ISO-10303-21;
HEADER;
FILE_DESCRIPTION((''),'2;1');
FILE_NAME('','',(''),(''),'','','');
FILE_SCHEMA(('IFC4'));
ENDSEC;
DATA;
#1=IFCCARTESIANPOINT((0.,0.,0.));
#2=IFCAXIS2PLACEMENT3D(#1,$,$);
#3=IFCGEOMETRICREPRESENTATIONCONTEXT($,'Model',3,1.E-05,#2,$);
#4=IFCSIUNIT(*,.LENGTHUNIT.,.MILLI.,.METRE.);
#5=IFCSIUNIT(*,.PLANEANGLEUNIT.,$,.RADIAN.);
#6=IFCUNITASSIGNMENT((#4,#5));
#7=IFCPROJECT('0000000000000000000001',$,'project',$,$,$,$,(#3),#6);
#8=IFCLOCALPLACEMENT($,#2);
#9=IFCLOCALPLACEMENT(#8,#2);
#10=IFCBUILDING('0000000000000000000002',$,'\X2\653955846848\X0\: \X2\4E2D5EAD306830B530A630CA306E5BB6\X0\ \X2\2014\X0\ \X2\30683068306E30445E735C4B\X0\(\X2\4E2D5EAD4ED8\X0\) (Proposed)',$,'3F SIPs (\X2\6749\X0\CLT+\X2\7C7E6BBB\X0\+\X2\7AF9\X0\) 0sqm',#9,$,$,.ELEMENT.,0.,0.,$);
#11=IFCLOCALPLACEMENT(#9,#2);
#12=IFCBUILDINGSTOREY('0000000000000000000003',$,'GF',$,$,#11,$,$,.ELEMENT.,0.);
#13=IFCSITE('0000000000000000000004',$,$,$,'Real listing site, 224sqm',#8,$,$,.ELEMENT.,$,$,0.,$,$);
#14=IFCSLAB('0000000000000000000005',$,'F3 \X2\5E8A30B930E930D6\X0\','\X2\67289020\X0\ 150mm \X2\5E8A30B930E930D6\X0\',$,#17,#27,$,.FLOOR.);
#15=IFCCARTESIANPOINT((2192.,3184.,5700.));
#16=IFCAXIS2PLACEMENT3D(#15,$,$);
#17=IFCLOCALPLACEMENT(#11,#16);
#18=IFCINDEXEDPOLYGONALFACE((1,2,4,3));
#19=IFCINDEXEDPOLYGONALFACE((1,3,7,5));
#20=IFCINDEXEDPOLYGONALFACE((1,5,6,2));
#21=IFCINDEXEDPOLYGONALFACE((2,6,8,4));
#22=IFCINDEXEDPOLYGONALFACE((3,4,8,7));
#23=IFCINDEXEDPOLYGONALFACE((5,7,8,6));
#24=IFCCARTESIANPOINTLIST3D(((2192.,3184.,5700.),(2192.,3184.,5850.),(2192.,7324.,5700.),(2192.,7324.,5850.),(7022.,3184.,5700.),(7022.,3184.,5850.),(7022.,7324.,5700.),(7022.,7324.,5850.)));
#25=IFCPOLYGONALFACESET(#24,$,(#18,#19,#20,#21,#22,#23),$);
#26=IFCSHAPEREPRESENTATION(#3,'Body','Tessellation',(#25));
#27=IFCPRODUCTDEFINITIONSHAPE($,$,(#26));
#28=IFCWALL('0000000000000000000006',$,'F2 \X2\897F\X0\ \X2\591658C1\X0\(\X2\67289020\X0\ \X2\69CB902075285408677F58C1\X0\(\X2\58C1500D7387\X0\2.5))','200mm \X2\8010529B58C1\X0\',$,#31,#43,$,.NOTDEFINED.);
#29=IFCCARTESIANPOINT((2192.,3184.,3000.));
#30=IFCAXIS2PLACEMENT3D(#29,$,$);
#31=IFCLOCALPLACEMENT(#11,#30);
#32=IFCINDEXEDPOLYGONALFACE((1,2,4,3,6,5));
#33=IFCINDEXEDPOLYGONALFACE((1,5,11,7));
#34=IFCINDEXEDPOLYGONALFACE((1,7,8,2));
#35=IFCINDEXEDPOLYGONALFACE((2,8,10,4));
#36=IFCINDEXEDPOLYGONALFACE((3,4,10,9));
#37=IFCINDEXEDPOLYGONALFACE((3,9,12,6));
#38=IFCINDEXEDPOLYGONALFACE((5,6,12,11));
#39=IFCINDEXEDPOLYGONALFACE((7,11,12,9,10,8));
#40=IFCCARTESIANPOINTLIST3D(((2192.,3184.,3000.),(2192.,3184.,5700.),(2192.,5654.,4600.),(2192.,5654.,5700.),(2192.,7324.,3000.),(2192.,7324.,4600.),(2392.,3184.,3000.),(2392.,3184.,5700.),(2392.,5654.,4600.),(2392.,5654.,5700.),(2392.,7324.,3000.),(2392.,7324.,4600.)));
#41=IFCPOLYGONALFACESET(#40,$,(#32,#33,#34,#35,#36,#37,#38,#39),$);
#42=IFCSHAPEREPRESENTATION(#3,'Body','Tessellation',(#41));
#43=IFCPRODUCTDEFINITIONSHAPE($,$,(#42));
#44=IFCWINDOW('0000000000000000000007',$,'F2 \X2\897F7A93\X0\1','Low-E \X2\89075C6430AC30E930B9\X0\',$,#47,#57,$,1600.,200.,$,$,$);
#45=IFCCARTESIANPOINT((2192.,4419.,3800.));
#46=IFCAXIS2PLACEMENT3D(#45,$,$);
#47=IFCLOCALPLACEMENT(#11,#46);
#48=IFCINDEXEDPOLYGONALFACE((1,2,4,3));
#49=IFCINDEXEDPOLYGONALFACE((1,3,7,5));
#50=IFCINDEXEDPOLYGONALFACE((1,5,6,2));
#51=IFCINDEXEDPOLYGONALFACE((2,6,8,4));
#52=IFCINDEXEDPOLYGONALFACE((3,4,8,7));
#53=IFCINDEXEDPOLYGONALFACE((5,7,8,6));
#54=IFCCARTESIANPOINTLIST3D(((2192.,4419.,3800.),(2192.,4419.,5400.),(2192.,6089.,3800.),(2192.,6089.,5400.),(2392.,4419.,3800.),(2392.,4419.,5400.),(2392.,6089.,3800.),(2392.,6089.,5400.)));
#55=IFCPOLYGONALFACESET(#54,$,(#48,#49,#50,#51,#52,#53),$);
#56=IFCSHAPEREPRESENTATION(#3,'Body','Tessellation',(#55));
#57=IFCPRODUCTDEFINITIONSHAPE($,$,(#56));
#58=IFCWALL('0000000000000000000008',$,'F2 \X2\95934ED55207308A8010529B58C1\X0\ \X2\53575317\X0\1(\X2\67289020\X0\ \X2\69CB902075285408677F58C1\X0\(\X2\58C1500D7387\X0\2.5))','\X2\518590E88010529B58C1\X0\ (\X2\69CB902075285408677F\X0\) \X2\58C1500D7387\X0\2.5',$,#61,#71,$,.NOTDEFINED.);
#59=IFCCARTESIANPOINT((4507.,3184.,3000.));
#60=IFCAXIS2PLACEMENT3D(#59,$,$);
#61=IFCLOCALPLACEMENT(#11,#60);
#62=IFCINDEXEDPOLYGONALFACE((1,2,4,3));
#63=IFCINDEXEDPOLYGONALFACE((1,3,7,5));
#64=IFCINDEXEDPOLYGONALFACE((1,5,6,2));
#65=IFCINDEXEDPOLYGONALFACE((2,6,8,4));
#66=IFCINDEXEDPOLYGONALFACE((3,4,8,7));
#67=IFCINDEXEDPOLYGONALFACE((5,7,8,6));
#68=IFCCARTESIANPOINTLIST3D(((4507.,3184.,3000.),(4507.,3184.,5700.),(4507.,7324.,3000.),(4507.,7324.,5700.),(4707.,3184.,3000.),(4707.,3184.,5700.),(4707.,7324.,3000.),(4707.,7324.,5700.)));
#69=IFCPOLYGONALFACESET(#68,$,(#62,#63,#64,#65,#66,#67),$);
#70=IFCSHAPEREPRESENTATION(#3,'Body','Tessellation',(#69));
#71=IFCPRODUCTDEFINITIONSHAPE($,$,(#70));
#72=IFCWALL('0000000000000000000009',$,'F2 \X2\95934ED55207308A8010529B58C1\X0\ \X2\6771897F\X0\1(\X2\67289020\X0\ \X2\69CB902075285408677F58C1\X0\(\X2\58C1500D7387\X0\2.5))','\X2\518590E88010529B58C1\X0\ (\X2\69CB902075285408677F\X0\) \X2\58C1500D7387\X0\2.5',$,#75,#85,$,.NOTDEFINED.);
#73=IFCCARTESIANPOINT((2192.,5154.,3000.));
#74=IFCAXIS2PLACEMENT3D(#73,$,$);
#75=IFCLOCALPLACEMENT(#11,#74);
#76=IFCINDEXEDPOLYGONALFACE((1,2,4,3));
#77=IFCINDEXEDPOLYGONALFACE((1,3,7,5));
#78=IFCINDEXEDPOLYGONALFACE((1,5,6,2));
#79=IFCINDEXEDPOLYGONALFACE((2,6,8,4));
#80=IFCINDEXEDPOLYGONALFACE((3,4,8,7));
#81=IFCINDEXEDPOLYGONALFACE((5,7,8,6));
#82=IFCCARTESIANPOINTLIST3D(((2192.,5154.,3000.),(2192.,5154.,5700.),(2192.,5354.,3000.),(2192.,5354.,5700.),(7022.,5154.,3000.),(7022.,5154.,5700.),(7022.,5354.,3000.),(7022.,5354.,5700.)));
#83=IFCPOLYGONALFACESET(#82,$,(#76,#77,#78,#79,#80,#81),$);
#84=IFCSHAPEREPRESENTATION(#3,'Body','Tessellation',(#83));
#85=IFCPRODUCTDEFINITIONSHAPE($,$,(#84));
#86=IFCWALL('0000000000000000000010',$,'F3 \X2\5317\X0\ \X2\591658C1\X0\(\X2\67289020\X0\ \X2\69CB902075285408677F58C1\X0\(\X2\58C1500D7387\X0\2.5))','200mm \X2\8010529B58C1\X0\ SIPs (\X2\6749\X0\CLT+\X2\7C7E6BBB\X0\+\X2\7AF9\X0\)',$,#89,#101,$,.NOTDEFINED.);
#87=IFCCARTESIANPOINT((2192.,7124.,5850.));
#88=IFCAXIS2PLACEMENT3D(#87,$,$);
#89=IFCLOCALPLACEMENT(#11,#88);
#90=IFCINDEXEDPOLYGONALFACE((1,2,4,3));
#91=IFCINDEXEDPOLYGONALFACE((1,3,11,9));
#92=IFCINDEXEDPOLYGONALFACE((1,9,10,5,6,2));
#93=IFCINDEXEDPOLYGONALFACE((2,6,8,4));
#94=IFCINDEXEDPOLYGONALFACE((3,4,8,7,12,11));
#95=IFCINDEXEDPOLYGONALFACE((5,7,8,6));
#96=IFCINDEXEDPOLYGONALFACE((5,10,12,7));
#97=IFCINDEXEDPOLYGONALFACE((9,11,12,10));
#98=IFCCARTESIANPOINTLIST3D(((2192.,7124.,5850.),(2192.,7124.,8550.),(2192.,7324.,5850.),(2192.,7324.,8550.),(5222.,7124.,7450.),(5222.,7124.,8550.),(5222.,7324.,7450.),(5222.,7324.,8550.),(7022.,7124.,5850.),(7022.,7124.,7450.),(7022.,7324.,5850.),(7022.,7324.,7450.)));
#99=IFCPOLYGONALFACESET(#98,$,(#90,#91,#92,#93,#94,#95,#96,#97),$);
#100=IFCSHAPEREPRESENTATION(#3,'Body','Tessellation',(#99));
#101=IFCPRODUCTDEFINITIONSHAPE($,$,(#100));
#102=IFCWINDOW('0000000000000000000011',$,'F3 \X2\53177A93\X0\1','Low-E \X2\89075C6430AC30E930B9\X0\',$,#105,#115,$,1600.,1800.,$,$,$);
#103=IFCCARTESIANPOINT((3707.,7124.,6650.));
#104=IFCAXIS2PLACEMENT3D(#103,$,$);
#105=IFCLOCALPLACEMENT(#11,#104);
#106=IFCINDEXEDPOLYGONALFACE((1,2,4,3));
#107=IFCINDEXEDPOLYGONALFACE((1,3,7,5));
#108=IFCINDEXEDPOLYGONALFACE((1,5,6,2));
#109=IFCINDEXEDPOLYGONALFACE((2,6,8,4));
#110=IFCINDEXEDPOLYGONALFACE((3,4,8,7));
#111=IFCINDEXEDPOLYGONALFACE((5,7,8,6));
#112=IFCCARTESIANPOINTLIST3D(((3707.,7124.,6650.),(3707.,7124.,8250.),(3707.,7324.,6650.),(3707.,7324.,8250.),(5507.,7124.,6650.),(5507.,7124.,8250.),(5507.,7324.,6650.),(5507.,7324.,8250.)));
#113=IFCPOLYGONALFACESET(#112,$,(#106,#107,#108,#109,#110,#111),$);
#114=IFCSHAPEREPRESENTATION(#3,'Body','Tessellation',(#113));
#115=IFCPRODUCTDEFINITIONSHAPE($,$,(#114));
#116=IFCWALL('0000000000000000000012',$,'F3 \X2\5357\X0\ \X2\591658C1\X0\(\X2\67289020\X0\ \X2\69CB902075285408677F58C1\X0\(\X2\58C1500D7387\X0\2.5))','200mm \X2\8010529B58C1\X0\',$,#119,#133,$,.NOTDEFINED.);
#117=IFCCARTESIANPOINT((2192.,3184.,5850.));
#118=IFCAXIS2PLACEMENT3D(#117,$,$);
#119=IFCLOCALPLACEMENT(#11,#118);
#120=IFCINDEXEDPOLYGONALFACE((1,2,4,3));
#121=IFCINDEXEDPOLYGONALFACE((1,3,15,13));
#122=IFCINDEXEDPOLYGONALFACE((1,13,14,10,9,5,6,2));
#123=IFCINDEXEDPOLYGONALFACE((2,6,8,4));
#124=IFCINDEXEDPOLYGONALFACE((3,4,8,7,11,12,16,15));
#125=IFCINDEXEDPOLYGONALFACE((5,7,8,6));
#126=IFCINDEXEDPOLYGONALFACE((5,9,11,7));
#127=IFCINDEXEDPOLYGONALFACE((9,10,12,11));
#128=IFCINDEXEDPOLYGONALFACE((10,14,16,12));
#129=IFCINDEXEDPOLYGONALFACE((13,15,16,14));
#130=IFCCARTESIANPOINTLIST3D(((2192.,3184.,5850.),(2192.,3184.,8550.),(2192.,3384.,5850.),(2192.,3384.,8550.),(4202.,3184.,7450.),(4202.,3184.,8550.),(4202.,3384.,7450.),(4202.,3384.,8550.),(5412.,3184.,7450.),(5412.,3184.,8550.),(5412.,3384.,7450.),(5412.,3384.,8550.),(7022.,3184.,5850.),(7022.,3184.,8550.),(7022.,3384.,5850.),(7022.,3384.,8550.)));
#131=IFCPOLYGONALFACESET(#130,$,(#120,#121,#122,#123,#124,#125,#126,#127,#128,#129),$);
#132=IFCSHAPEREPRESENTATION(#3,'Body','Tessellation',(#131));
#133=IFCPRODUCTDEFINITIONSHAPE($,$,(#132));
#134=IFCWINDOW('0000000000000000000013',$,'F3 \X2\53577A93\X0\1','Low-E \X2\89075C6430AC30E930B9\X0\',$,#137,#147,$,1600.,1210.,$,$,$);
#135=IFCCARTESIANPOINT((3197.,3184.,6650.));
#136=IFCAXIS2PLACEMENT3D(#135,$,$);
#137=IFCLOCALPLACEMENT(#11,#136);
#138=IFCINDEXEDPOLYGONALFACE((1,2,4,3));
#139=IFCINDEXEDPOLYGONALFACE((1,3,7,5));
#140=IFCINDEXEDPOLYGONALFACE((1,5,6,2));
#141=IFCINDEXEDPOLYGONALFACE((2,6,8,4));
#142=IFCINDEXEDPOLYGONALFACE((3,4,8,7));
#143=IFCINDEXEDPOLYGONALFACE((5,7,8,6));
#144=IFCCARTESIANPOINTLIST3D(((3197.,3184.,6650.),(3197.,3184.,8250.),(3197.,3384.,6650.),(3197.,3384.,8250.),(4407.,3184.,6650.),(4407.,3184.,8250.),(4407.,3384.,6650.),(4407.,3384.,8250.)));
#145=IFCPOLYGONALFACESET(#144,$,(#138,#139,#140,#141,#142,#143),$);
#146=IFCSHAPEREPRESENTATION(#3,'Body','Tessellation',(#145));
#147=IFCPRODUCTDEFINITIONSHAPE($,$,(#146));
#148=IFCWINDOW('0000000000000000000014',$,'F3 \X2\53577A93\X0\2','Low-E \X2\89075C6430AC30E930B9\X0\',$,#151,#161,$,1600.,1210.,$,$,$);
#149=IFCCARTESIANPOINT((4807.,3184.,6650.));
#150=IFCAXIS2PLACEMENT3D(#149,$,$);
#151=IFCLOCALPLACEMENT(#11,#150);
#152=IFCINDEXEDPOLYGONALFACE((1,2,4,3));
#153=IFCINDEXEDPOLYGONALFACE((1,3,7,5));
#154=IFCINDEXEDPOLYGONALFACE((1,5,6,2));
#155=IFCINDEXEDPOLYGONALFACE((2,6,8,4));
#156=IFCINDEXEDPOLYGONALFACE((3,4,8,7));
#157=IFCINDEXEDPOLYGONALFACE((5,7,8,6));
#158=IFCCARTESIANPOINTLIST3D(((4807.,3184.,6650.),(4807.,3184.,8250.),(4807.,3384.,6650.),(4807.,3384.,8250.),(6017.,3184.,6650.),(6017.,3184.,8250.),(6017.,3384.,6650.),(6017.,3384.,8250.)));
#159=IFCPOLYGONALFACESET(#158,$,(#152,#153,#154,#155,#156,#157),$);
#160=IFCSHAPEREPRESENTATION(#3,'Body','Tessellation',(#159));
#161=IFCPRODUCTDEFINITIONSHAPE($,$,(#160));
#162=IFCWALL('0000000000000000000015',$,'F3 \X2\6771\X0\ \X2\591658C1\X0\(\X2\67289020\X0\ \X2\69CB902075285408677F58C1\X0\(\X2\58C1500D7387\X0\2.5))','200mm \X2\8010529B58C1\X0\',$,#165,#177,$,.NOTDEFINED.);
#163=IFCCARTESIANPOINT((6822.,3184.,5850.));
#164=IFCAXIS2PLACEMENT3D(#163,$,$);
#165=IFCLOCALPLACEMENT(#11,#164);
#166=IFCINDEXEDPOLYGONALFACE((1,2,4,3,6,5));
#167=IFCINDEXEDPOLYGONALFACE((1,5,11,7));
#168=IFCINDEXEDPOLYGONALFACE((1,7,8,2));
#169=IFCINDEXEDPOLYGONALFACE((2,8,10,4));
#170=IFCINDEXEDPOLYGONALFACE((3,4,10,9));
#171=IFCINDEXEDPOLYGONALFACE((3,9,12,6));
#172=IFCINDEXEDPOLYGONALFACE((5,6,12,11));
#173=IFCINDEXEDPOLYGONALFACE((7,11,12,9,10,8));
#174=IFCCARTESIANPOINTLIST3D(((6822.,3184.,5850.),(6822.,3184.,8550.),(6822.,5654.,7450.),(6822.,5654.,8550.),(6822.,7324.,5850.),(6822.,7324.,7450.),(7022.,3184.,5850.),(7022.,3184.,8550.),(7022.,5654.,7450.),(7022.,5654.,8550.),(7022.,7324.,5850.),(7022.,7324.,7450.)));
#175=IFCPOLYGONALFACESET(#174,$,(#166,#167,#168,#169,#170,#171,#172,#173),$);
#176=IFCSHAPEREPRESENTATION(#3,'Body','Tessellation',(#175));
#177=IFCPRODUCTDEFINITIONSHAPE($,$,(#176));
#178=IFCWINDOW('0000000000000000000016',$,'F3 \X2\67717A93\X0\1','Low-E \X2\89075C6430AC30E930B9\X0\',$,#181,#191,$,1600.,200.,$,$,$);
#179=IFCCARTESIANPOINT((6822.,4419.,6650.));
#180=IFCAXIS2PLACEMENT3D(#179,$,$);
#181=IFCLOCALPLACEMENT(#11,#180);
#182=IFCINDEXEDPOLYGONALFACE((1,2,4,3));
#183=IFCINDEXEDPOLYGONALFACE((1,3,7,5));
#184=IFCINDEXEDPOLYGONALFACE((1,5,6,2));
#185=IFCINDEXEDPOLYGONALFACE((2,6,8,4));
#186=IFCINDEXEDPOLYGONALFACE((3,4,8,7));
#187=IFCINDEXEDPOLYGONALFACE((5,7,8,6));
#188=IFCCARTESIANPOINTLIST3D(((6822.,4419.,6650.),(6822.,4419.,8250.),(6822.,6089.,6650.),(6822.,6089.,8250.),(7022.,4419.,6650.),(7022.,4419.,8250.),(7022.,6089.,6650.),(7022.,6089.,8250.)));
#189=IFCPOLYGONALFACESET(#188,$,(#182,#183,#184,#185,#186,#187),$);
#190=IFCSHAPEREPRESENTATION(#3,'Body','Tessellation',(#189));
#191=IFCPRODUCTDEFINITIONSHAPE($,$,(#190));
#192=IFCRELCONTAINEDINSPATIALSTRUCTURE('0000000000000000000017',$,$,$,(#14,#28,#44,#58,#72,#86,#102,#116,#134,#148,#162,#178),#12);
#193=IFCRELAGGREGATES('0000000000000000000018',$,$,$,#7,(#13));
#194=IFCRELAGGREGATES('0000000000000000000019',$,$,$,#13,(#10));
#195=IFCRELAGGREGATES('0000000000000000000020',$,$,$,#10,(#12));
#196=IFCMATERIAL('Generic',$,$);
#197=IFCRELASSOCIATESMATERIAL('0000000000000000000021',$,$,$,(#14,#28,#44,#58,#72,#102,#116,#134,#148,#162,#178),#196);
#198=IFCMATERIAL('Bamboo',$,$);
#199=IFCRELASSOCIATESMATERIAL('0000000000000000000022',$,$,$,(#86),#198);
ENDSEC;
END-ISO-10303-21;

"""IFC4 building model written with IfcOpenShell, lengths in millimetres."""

from ifc_helpers import new_model, si_unit, frame, frame_2d, origin, place, context, project, spatial, rectangle, extrude, material, element, fill, save


model = new_model("IFC4")

# Units and contexts
model_context = context("Model", 3, precision=1e-05, world=origin())
ifc_project = project(units=[si_unit("LENGTHUNIT", "METRE", prefix="MILLI"), si_unit("PLANEANGLEUNIT", "RADIAN")], contexts=[model_context])

# Site, building, storey
site_placement = place(None, origin())
site = spatial("IfcSite", under=ifc_project, at=site_placement, ObjectType="Real listing site, 224sqm", CompositionType="ELEMENT", RefElevation=0.0)
building_placement = place(site_placement, origin())
building = spatial("IfcBuilding", under=site, at=building_placement, Name="改善案: 中庭とサウナの家 — ととのい平屋(中庭付) (Proposed)", ObjectType="3F SIPs (杉CLT+籾殻+竹) 0sqm", CompositionType="ELEMENT", ElevationOfRefHeight=0.0, ElevationOfTerrain=0.0)
storey_placement = place(building_placement, origin())
storey = spatial("IfcBuildingStorey", under=building, at=storey_placement, Name="GF", CompositionType="ELEMENT", Elevation=0.0)

# Slab
ifc_material_1 = material(Name="Generic")
slab_placement = place(storey_placement, frame((2192.0, 3184.0, 5700.0)))
element("IfcSlab", 1, at=slab_placement, inside=storey, material=ifc_material_1, Name="F3 床スラブ", Description="木造 150mm 床スラブ", PredefinedType="FLOOR", context=model_context, shape_type="SweptSolid", body=[
    extrude(rectangle(XDim=4830.0, YDim=4140.0, at=frame_2d((2415.0, 2070.0))), frame((2192.0, 3184.0, 5700.0)), (0.0, 0.0, 1.0), 150.0),
])

# Wall, opening, window
wall_1_placement = place(storey_placement, frame((2192.0, 3184.0, 3000.0)))
wall_1 = element("IfcWall", 2, at=wall_1_placement, inside=storey, material=ifc_material_1, Name="F2 西 外壁(木造 構造用合板壁(壁倍率2.5))", Description="200mm 耐力壁", PredefinedType="NOTDEFINED", context=model_context, shape_type="SweptSolid", body=[
    extrude(rectangle(XDim=200.0, YDim=4140.0, at=frame_2d((100.0, 2070.0))), frame((2192.0, 3184.0, 3000.0)), (0.0, 0.0, 1.0), 2700.0),
])
opening_1_placement = place(storey_placement, frame((2192.0, 4419.0, 3800.0)))
opening_1 = element("IfcOpeningElement", 3, at=opening_1_placement, cuts=wall_1, PredefinedType="NOTDEFINED", context=model_context, shape_type="SweptSolid", body=[
    extrude(rectangle(XDim=200.0, YDim=1670.0, at=frame_2d((100.0, 835.0))), frame((2192.0, 4419.0, 3800.0)), (0.0, 0.0, 1.0), 1600.0),
])
window_1_placement = place(storey_placement, frame((2192.0, 4419.0, 3800.0)))
window_1 = element("IfcWindow", 4, at=window_1_placement, inside=storey, material=ifc_material_1, Name="F2 西窓1", Description="Low-E 複層ガラス", OverallHeight=1600.0, OverallWidth=200.0, context=model_context, shape_type="SweptSolid", body=[
    extrude(rectangle(XDim=200.0, YDim=1670.0, at=frame_2d((100.0, 835.0))), frame((2192.0, 4419.0, 3800.0)), (0.0, 0.0, 1.0), 1600.0),
])
fill(opening_1, window_1)

# Walls
wall_2_placement = place(storey_placement, frame((4507.0, 3184.0, 3000.0)))
element("IfcWall", 5, at=wall_2_placement, inside=storey, material=ifc_material_1, Name="F2 間仕切り耐力壁 南北1(木造 構造用合板壁(壁倍率2.5))", Description="内部耐力壁 (構造用合板) 壁倍率2.5", PredefinedType="NOTDEFINED", context=model_context, shape_type="SweptSolid", body=[
    extrude(rectangle(XDim=200.0, YDim=4140.0, at=frame_2d((100.0, 2070.0))), frame((4507.0, 3184.0, 3000.0)), (0.0, 0.0, 1.0), 2700.0),
])
wall_3_placement = place(storey_placement, frame((2192.0, 5154.0, 3000.0)))
element("IfcWall", 6, at=wall_3_placement, inside=storey, material=ifc_material_1, Name="F2 間仕切り耐力壁 東西1(木造 構造用合板壁(壁倍率2.5))", Description="内部耐力壁 (構造用合板) 壁倍率2.5", PredefinedType="NOTDEFINED", context=model_context, shape_type="SweptSolid", body=[
    extrude(rectangle(XDim=4830.0, YDim=200.0, at=frame_2d((2415.0, 100.0))), frame((2192.0, 5154.0, 3000.0)), (0.0, 0.0, 1.0), 2700.0),
])

# Wall, opening, window
ifc_material_2 = material(Name="Bamboo")
wall_4_placement = place(storey_placement, frame((2192.0, 7124.0, 5850.0)))
wall_4 = element("IfcWall", 7, at=wall_4_placement, inside=storey, material=ifc_material_2, Name="F3 北 外壁(木造 構造用合板壁(壁倍率2.5))", Description="200mm 耐力壁 SIPs (杉CLT+籾殻+竹)", PredefinedType="NOTDEFINED", context=model_context, shape_type="SweptSolid", body=[
    extrude(rectangle(XDim=4830.0, YDim=200.0, at=frame_2d((2415.0, 100.0))), frame((2192.0, 7124.0, 5850.0)), (0.0, 0.0, 1.0), 2700.0),
])
opening_2_placement = place(storey_placement, frame((3707.0, 7124.0, 6650.0)))
opening_2 = element("IfcOpeningElement", 8, at=opening_2_placement, cuts=wall_4, PredefinedType="NOTDEFINED", context=model_context, shape_type="SweptSolid", body=[
    extrude(rectangle(XDim=1800.0, YDim=200.0, at=frame_2d((900.0, 100.0))), frame((3707.0, 7124.0, 6650.0)), (0.0, 0.0, 1.0), 1600.0),
])
window_2_placement = place(storey_placement, frame((3707.0, 7124.0, 6650.0)))
window_2 = element("IfcWindow", 9, at=window_2_placement, inside=storey, material=ifc_material_1, Name="F3 北窓1", Description="Low-E 複層ガラス", OverallHeight=1600.0, OverallWidth=1800.0, context=model_context, shape_type="SweptSolid", body=[
    extrude(rectangle(XDim=1800.0, YDim=200.0, at=frame_2d((900.0, 100.0))), frame((3707.0, 7124.0, 6650.0)), (0.0, 0.0, 1.0), 1600.0),
])
fill(opening_2, window_2)

# Wall, openings, windows
wall_5_placement = place(storey_placement, frame((2192.0, 3184.0, 5850.0)))
wall_5 = element("IfcWall", 10, at=wall_5_placement, inside=storey, material=ifc_material_1, Name="F3 南 外壁(木造 構造用合板壁(壁倍率2.5))", Description="200mm 耐力壁", PredefinedType="NOTDEFINED", context=model_context, shape_type="SweptSolid", body=[
    extrude(rectangle(XDim=4830.0, YDim=200.0, at=frame_2d((2415.0, 100.0))), frame((2192.0, 3184.0, 5850.0)), (0.0, 0.0, 1.0), 2700.0),
])
opening_3_placement = place(storey_placement, frame((3197.0, 3184.0, 6650.0)))
opening_3 = element("IfcOpeningElement", 11, at=opening_3_placement, cuts=wall_5, PredefinedType="NOTDEFINED", context=model_context, shape_type="SweptSolid", body=[
    extrude(rectangle(XDim=1210.0, YDim=200.0, at=frame_2d((605.0, 100.0))), frame((3197.0, 3184.0, 6650.0)), (0.0, 0.0, 1.0), 1600.0),
])
opening_4_placement = place(storey_placement, frame((4807.0, 3184.0, 6650.0)))
opening_4 = element("IfcOpeningElement", 12, at=opening_4_placement, cuts=wall_5, PredefinedType="NOTDEFINED", context=model_context, shape_type="SweptSolid", body=[
    extrude(rectangle(XDim=1210.0, YDim=200.0, at=frame_2d((605.0, 100.0))), frame((4807.0, 3184.0, 6650.0)), (0.0, 0.0, 1.0), 1600.0),
])
window_3_placement = place(storey_placement, frame((3197.0, 3184.0, 6650.0)))
window_3 = element("IfcWindow", 13, at=window_3_placement, inside=storey, material=ifc_material_1, Name="F3 南窓1", Description="Low-E 複層ガラス", OverallHeight=1600.0, OverallWidth=1210.0, context=model_context, shape_type="SweptSolid", body=[
    extrude(rectangle(XDim=1210.0, YDim=200.0, at=frame_2d((605.0, 100.0))), frame((3197.0, 3184.0, 6650.0)), (0.0, 0.0, 1.0), 1600.0),
])
fill(opening_3, window_3)
window_4_placement = place(storey_placement, frame((4807.0, 3184.0, 6650.0)))
window_4 = element("IfcWindow", 14, at=window_4_placement, inside=storey, material=ifc_material_1, Name="F3 南窓2", Description="Low-E 複層ガラス", OverallHeight=1600.0, OverallWidth=1210.0, context=model_context, shape_type="SweptSolid", body=[
    extrude(rectangle(XDim=1210.0, YDim=200.0, at=frame_2d((605.0, 100.0))), frame((4807.0, 3184.0, 6650.0)), (0.0, 0.0, 1.0), 1600.0),
])
fill(opening_4, window_4)

# Wall, opening, window
wall_6_placement = place(storey_placement, frame((6822.0, 3184.0, 5850.0)))
wall_6 = element("IfcWall", 15, at=wall_6_placement, inside=storey, material=ifc_material_1, Name="F3 東 外壁(木造 構造用合板壁(壁倍率2.5))", Description="200mm 耐力壁", PredefinedType="NOTDEFINED", context=model_context, shape_type="SweptSolid", body=[
    extrude(rectangle(XDim=200.0, YDim=4140.0, at=frame_2d((100.0, 2070.0))), frame((6822.0, 3184.0, 5850.0)), (0.0, 0.0, 1.0), 2700.0),
])
opening_5_placement = place(storey_placement, frame((6822.0, 4419.0, 6650.0)))
opening_5 = element("IfcOpeningElement", 16, at=opening_5_placement, cuts=wall_6, PredefinedType="NOTDEFINED", context=model_context, shape_type="SweptSolid", body=[
    extrude(rectangle(XDim=200.0, YDim=1670.0, at=frame_2d((100.0, 835.0))), frame((6822.0, 4419.0, 6650.0)), (0.0, 0.0, 1.0), 1600.0),
])
window_5_placement = place(storey_placement, frame((6822.0, 4419.0, 6650.0)))
window_5 = element("IfcWindow", 17, at=window_5_placement, inside=storey, material=ifc_material_1, Name="F3 東窓1", Description="Low-E 複層ガラス", OverallHeight=1600.0, OverallWidth=200.0, context=model_context, shape_type="SweptSolid", body=[
    extrude(rectangle(XDim=200.0, YDim=1670.0, at=frame_2d((100.0, 835.0))), frame((6822.0, 4419.0, 6650.0)), (0.0, 0.0, 1.0), 1600.0),
])
fill(opening_5, window_5)

save(model, "model.ifc")
